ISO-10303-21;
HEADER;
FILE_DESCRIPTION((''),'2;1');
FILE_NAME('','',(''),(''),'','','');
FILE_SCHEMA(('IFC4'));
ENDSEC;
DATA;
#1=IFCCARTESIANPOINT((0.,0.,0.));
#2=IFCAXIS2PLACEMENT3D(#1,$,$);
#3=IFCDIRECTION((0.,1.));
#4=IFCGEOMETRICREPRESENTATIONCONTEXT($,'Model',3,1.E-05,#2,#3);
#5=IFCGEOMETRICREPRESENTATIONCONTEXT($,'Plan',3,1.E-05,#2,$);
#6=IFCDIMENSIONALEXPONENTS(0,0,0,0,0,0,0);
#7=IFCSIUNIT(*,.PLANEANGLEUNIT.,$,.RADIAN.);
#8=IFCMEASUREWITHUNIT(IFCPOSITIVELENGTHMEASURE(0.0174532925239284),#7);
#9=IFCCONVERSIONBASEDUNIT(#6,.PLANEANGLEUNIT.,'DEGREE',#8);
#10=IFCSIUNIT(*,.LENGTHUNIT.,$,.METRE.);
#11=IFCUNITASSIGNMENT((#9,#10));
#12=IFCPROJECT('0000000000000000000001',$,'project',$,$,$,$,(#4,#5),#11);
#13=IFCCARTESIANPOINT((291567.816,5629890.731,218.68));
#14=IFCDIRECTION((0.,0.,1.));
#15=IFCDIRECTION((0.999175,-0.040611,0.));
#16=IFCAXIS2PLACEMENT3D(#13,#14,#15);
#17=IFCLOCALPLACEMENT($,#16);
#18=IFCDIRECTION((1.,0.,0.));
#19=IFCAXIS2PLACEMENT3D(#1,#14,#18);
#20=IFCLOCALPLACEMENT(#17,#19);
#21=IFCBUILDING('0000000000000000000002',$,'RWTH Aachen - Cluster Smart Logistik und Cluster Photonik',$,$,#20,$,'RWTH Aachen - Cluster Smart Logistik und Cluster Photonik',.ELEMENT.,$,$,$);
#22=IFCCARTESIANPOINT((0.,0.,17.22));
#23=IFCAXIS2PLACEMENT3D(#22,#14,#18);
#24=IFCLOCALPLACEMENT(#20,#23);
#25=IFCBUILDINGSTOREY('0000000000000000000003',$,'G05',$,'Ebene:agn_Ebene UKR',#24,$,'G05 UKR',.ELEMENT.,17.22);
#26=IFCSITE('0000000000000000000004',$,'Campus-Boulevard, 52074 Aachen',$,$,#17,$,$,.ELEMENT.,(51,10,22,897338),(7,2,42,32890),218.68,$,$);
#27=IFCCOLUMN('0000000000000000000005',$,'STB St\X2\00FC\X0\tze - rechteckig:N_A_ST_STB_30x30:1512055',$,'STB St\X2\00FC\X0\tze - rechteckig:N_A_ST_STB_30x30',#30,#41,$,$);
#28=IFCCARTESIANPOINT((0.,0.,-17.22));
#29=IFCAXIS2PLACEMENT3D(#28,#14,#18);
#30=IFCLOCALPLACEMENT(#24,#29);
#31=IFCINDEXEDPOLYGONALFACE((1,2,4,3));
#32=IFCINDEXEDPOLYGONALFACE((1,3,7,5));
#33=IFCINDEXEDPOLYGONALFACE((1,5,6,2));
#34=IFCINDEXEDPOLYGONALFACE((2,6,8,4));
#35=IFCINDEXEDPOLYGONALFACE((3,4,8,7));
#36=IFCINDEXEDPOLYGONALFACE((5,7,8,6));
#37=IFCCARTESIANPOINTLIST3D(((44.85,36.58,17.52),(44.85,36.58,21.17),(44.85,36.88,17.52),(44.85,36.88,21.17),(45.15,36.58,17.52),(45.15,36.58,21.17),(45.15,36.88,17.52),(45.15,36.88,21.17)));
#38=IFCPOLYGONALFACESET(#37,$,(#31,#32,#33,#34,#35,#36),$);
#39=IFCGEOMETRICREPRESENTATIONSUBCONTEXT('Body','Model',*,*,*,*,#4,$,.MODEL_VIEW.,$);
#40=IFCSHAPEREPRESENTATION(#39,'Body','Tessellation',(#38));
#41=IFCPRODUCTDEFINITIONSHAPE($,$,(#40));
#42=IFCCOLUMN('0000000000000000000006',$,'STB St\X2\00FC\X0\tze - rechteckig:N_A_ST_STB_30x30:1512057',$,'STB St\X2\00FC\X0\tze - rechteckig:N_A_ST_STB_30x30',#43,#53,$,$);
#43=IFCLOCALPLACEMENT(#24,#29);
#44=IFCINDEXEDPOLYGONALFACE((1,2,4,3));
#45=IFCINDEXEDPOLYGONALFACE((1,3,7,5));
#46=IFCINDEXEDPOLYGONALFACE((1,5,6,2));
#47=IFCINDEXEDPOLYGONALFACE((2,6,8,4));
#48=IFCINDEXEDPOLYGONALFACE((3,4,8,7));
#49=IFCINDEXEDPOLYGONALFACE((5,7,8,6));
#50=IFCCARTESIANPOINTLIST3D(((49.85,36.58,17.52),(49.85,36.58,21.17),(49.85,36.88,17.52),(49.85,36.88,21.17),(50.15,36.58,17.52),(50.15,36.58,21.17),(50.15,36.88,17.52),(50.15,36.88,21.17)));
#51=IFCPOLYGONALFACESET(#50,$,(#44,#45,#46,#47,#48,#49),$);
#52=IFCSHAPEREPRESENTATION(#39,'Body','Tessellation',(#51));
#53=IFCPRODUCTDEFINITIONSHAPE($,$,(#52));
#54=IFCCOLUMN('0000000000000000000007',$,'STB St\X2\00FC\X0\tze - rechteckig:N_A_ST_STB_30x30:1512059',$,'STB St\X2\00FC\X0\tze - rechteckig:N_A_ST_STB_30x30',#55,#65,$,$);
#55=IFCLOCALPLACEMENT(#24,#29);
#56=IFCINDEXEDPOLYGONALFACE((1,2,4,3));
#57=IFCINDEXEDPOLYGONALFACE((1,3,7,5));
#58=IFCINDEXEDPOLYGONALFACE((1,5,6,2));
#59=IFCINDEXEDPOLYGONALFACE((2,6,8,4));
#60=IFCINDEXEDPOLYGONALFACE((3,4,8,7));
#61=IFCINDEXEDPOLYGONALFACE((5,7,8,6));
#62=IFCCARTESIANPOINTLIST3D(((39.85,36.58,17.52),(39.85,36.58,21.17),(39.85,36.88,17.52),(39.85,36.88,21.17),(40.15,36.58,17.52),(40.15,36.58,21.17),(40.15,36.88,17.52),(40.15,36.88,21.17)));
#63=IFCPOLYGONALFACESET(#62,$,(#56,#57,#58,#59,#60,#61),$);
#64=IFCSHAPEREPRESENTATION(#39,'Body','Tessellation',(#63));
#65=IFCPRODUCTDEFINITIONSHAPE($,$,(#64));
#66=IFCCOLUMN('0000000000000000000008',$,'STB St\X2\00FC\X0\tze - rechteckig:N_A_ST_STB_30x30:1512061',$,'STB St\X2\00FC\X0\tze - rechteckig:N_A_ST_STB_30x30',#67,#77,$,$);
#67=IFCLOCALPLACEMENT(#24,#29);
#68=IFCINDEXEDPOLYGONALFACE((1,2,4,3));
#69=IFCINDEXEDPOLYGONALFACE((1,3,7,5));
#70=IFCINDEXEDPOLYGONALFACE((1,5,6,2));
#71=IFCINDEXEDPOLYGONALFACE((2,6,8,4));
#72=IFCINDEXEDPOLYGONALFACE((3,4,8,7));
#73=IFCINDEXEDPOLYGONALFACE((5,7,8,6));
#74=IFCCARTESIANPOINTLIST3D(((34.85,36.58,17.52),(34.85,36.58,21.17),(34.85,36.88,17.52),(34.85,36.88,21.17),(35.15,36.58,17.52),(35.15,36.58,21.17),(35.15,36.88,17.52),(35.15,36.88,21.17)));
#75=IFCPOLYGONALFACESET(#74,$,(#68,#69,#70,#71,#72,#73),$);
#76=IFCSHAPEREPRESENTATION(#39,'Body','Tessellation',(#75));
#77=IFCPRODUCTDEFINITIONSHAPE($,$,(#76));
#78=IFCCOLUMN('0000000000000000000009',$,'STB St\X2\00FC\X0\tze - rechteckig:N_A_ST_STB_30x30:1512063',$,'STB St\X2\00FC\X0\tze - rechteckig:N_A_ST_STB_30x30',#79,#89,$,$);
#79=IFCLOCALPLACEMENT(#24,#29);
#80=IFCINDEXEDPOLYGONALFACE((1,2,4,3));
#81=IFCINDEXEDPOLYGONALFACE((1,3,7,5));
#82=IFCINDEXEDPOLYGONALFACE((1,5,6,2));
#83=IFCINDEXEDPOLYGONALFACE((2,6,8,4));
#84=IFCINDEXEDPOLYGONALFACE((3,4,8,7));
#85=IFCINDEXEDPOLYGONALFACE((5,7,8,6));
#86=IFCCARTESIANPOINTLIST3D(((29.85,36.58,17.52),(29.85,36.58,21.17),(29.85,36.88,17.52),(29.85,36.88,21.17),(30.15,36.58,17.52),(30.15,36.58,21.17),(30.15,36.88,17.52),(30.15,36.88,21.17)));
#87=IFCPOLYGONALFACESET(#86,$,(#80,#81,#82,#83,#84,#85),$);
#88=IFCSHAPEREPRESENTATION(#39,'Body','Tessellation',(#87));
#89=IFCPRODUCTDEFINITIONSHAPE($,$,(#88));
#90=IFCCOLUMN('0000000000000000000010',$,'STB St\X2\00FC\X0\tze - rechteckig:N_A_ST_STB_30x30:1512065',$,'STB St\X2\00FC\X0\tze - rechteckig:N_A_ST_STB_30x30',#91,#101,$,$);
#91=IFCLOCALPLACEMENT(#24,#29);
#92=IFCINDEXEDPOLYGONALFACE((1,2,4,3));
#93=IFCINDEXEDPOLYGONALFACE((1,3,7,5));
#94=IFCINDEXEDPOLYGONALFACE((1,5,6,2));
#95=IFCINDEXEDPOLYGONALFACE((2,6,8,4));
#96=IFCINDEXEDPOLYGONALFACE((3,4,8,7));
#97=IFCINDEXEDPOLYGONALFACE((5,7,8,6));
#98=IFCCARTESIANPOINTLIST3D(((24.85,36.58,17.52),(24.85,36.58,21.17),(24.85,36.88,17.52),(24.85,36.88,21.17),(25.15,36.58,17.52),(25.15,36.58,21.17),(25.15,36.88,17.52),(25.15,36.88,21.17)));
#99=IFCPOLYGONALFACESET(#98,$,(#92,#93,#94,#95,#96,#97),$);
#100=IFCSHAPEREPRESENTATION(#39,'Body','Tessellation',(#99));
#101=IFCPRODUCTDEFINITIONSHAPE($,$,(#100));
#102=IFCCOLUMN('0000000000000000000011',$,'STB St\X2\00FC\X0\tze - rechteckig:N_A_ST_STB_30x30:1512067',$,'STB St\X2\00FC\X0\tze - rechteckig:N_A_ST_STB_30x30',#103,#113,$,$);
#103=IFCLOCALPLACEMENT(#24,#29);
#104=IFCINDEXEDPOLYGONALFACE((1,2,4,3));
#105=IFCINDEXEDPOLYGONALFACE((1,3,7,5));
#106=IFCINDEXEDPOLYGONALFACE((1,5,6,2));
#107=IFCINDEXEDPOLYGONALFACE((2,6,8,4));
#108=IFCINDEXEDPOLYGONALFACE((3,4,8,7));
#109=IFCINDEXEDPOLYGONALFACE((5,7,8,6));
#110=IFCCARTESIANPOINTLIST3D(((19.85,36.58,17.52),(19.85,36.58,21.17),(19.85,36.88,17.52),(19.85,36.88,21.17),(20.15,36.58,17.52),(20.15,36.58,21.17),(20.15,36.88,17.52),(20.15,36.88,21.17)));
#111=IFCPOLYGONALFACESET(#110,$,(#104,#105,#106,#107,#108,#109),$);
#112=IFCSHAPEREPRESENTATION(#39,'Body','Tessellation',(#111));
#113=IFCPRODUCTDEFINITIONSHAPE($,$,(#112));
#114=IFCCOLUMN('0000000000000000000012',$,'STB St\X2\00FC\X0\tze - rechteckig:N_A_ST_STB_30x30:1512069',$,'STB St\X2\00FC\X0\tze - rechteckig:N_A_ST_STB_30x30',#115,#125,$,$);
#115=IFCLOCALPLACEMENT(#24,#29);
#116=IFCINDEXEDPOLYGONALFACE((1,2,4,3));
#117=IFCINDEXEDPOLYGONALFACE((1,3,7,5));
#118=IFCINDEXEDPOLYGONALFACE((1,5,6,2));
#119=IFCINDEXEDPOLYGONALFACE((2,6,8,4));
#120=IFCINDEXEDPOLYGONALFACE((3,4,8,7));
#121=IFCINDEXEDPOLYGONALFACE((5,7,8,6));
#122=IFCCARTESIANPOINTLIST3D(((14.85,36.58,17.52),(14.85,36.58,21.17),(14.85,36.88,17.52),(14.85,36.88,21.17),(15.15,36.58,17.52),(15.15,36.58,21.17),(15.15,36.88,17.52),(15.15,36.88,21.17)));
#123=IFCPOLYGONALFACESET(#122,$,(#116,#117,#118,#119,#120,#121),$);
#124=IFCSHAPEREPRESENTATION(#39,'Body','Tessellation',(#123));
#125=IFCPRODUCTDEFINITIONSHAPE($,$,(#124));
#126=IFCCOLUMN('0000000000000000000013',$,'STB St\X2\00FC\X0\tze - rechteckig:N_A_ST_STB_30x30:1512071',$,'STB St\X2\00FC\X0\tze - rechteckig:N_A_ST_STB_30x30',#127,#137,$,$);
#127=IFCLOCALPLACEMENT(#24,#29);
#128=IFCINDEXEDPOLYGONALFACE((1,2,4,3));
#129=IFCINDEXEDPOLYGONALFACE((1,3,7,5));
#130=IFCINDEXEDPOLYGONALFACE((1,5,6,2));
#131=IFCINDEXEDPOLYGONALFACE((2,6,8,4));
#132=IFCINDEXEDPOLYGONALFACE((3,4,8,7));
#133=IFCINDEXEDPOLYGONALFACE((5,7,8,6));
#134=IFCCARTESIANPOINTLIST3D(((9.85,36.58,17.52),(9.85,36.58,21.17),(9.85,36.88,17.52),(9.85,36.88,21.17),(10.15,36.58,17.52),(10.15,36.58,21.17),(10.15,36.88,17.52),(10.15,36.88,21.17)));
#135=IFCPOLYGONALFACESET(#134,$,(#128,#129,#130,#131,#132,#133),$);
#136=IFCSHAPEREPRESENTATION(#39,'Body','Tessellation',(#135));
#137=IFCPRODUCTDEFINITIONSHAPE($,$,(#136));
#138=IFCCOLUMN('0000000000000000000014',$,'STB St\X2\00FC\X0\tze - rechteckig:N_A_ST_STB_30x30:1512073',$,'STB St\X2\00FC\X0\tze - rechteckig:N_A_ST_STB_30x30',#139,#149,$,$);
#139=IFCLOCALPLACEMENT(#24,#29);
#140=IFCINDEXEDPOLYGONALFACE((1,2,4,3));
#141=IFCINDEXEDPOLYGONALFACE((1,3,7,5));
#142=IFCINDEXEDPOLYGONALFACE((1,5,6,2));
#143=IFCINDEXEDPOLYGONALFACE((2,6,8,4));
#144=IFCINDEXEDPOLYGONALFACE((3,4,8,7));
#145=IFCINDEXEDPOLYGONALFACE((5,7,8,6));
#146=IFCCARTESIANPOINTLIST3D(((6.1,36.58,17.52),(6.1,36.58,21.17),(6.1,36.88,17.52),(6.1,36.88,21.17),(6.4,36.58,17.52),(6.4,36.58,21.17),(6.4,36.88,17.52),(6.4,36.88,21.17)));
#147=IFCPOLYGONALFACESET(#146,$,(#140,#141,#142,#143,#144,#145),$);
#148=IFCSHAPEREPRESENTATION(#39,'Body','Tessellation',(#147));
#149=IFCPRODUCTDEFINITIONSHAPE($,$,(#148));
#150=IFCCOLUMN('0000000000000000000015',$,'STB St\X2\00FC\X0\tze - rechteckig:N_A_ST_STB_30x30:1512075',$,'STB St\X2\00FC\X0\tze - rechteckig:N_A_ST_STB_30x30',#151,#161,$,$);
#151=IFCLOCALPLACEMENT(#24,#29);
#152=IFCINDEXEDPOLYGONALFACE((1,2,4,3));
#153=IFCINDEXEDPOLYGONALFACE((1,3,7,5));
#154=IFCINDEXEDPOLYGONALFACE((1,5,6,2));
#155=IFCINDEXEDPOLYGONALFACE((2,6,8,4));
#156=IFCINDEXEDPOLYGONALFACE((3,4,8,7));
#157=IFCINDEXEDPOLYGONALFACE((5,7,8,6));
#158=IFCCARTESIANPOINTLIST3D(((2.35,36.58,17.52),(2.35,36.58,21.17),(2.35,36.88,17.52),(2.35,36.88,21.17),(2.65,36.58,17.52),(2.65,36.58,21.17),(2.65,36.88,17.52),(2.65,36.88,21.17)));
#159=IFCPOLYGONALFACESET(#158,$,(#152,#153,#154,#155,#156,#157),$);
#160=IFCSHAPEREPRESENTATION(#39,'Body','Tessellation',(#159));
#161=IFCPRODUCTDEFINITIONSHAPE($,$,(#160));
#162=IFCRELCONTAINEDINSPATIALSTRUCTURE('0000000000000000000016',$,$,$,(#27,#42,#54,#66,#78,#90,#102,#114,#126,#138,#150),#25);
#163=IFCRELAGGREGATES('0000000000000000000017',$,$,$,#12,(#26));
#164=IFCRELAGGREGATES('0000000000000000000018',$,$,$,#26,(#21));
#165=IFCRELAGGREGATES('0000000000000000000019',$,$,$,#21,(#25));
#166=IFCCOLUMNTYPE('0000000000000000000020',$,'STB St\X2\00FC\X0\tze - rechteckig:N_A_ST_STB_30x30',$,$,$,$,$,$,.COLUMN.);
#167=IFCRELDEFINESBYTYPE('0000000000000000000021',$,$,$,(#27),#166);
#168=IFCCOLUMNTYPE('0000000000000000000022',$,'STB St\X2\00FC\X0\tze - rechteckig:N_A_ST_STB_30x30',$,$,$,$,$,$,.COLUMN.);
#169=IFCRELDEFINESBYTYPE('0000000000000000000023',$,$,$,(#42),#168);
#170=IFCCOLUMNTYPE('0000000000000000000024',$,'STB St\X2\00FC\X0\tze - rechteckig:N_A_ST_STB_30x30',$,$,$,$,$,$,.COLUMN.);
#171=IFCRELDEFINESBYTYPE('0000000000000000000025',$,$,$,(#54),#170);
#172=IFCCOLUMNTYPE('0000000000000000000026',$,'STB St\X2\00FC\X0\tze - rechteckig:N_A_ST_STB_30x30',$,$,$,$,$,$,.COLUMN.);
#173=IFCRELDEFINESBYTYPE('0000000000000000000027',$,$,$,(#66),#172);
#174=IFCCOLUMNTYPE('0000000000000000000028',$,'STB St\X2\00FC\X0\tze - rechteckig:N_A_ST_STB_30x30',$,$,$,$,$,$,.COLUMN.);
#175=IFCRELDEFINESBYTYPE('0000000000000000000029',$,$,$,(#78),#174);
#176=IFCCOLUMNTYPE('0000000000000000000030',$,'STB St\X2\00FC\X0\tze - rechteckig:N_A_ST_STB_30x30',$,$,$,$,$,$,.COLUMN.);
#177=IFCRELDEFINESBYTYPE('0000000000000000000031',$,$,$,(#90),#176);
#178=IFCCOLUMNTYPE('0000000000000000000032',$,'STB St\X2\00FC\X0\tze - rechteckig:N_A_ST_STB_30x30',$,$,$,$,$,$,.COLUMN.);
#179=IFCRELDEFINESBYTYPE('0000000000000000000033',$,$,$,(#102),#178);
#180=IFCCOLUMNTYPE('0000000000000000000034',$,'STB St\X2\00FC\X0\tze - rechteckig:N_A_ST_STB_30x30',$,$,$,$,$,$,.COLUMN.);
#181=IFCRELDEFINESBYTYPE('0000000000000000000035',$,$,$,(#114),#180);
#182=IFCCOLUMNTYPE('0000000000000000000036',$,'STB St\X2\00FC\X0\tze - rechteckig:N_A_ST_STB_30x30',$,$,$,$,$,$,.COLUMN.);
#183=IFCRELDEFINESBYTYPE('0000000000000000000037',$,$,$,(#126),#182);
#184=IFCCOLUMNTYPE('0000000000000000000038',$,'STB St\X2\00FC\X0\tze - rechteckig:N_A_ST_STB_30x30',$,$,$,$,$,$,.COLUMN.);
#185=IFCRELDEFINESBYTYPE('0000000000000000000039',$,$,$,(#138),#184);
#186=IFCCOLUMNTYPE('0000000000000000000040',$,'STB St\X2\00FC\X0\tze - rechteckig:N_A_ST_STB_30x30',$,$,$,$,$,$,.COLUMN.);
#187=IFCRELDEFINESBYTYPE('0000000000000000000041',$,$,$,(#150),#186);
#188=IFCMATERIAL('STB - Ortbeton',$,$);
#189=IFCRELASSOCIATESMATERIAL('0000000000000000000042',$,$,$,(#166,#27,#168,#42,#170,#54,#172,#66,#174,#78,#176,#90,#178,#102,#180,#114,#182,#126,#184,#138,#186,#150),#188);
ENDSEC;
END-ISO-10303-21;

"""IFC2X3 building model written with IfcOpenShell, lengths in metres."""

from ifc_helpers import new_model, entity, si_unit, converted_unit, direction, frame, frame_2d, origin, origin_with_axes, origin_2d_with_axis, place, context, subcontext, project, spatial, rectangle, extrude, source, transform, mapped, material, type_object, element, save


model = new_model("IFC2X3")

# Units and contexts
model_context = context("Model", 3, precision=1e-05, world=origin(), true_north=direction((0.0, 1.0)))
plan_context = context("Plan", 3, precision=1e-05, world=origin())
body_context = subcontext(model_context, "Body", "Model", "MODEL_VIEW")
ifc_project = project(units=[converted_unit("PLANEANGLEUNIT", "DEGREE", entity("IfcPositiveLengthMeasure", 0.0174532925239284), si_unit("PLANEANGLEUNIT", "RADIAN"), dimensions=[0, 0, 0, 0, 0, 0, 0]), si_unit("LENGTHUNIT", "METRE")], contexts=[model_context, plan_context])

# Site, building, storey
site_placement = place(None, frame((291567.816, 5629890.731, 218.68), z_axis=(0.0, 0.0, 1.0), x_axis=(0.999175, -0.040611, 0.0)))
site = spatial("IfcSite", under=ifc_project, at=site_placement, Name="Campus-Boulevard, 52074 Aachen", CompositionType="ELEMENT", RefLatitude=(51, 10, 22, 897338), RefLongitude=(7, 2, 42, 32890), RefElevation=218.68)
building_placement = place(site_placement, origin_with_axes())
building = spatial("IfcBuilding", under=site, at=building_placement, Name="RWTH Aachen - Cluster Smart Logistik und Cluster Photonik", LongName="RWTH Aachen - Cluster Smart Logistik und Cluster Photonik", CompositionType="ELEMENT")
storey_placement = place(building_placement, frame((0.0, 0.0, 17.22), z_axis=(0.0, 0.0, 1.0), x_axis=(1.0, 0.0, 0.0)))
storey = spatial("IfcBuildingStorey", under=building, at=storey_placement, Name="G05", ObjectType="Ebene:agn_Ebene UKR", LongName="G05 UKR", CompositionType="ELEMENT", Elevation=17.22)

# Columns
ifc_material = material(Name="STB - Ortbeton")
column_type_1 = type_object("IfcColumnType", Name="STB Stütze - rechteckig:N_A_ST_STB_30x30", PredefinedType="COLUMN", material=ifc_material)
shared_shape_1 = source(origin(), body_context, "Body", "SweptSolid", [
    extrude(rectangle(XDim=0.3, YDim=0.3, at=origin_2d_with_axis()), frame((45.0, 36.73, 17.52), z_axis=(0.0, 0.0, 1.0), x_axis=(0.0, -1.0, 0.0)), (0.0, 0.0, 1.0), 3.65),
])
column_1_placement = place(storey_placement, frame((0.0, 0.0, -17.22), z_axis=(0.0, 0.0, 1.0), x_axis=(1.0, 0.0, 0.0)))
element("IfcColumn", 1, at=column_1_placement, inside=storey, type_object=column_type_1, material=ifc_material, Name="STB Stütze - rechteckig:N_A_ST_STB_30x30:1512055", ObjectType="STB Stütze - rechteckig:N_A_ST_STB_30x30", context=body_context, shape_type="MappedRepresentation", body=[
    mapped(shared_shape_1, transform((0.0, 0.0, 0.0), scale=1.0)),
])
column_type_2 = type_object("IfcColumnType", Name="STB Stütze - rechteckig:N_A_ST_STB_30x30", PredefinedType="COLUMN", material=ifc_material)
shared_shape_2 = source(origin(), body_context, "Body", "SweptSolid", [
    extrude(rectangle(XDim=0.3, YDim=0.3, at=origin_2d_with_axis()), frame((50.0, 36.73, 17.52), z_axis=(0.0, 0.0, 1.0), x_axis=(0.0, -1.0, 0.0)), (0.0, 0.0, 1.0), 3.65),
])
column_2_placement = place(storey_placement, frame((0.0, 0.0, -17.22), z_axis=(0.0, 0.0, 1.0), x_axis=(1.0, 0.0, 0.0)))
element("IfcColumn", 2, at=column_2_placement, inside=storey, type_object=column_type_2, material=ifc_material, Name="STB Stütze - rechteckig:N_A_ST_STB_30x30:1512057", ObjectType="STB Stütze - rechteckig:N_A_ST_STB_30x30", context=body_context, shape_type="MappedRepresentation", body=[
    mapped(shared_shape_2, transform((0.0, 0.0, 0.0), scale=1.0)),
])
column_type_3 = type_object("IfcColumnType", Name="STB Stütze - rechteckig:N_A_ST_STB_30x30", PredefinedType="COLUMN", material=ifc_material)
shared_shape_3 = source(origin(), body_context, "Body", "SweptSolid", [
    extrude(rectangle(XDim=0.3, YDim=0.3, at=origin_2d_with_axis()), frame((40.0, 36.73, 17.52), z_axis=(0.0, 0.0, 1.0), x_axis=(0.0, -1.0, 0.0)), (0.0, 0.0, 1.0), 3.65),
])
column_3_placement = place(storey_placement, frame((0.0, 0.0, -17.22), z_axis=(0.0, 0.0, 1.0), x_axis=(1.0, 0.0, 0.0)))
element("IfcColumn", 3, at=column_3_placement, inside=storey, type_object=column_type_3, material=ifc_material, Name="STB Stütze - rechteckig:N_A_ST_STB_30x30:1512059", ObjectType="STB Stütze - rechteckig:N_A_ST_STB_30x30", context=body_context, shape_type="MappedRepresentation", body=[
    mapped(shared_shape_3, transform((0.0, 0.0, 0.0), scale=1.0)),
])
column_type_4 = type_object("IfcColumnType", Name="STB Stütze - rechteckig:N_A_ST_STB_30x30", PredefinedType="COLUMN", material=ifc_material)
shared_shape_4 = source(origin(), body_context, "Body", "SweptSolid", [
    extrude(rectangle(XDim=0.3, YDim=0.3, at=origin_2d_with_axis()), frame((35.0, 36.73, 17.52), z_axis=(0.0, 0.0, 1.0), x_axis=(0.0, -1.0, 0.0)), (0.0, 0.0, 1.0), 3.65),
])
column_4_placement = place(storey_placement, frame((0.0, 0.0, -17.22), z_axis=(0.0, 0.0, 1.0), x_axis=(1.0, 0.0, 0.0)))
element("IfcColumn", 4, at=column_4_placement, inside=storey, type_object=column_type_4, material=ifc_material, Name="STB Stütze - rechteckig:N_A_ST_STB_30x30:1512061", ObjectType="STB Stütze - rechteckig:N_A_ST_STB_30x30", context=body_context, shape_type="MappedRepresentation", body=[
    mapped(shared_shape_4, transform((0.0, 0.0, 0.0), scale=1.0)),
])
column_type_5 = type_object("IfcColumnType", Name="STB Stütze - rechteckig:N_A_ST_STB_30x30", PredefinedType="COLUMN", material=ifc_material)
shared_shape_5 = source(origin(), body_context, "Body", "SweptSolid", [
    extrude(rectangle(XDim=0.3, YDim=0.3, at=origin_2d_with_axis()), frame((30.0, 36.73, 17.52), z_axis=(0.0, 0.0, 1.0), x_axis=(0.0, -1.0, 0.0)), (0.0, 0.0, 1.0), 3.65),
])
column_5_placement = place(storey_placement, frame((0.0, 0.0, -17.22), z_axis=(0.0, 0.0, 1.0), x_axis=(1.0, 0.0, 0.0)))
element("IfcColumn", 5, at=column_5_placement, inside=storey, type_object=column_type_5, material=ifc_material, Name="STB Stütze - rechteckig:N_A_ST_STB_30x30:1512063", ObjectType="STB Stütze - rechteckig:N_A_ST_STB_30x30", context=body_context, shape_type="MappedRepresentation", body=[
    mapped(shared_shape_5, transform((0.0, 0.0, 0.0), scale=1.0)),
])
column_type_6 = type_object("IfcColumnType", Name="STB Stütze - rechteckig:N_A_ST_STB_30x30", PredefinedType="COLUMN", material=ifc_material)
shared_shape_6 = source(origin(), body_context, "Body", "SweptSolid", [
    extrude(rectangle(XDim=0.3, YDim=0.3, at=origin_2d_with_axis()), frame((25.0, 36.73, 17.52), z_axis=(0.0, 0.0, 1.0), x_axis=(0.0, -1.0, 0.0)), (0.0, 0.0, 1.0), 3.65),
])
column_6_placement = place(storey_placement, frame((0.0, 0.0, -17.22), z_axis=(0.0, 0.0, 1.0), x_axis=(1.0, 0.0, 0.0)))
element("IfcColumn", 6, at=column_6_placement, inside=storey, type_object=column_type_6, material=ifc_material, Name="STB Stütze - rechteckig:N_A_ST_STB_30x30:1512065", ObjectType="STB Stütze - rechteckig:N_A_ST_STB_30x30", context=body_context, shape_type="MappedRepresentation", body=[
    mapped(shared_shape_6, transform((0.0, 0.0, 0.0), scale=1.0)),
])
column_type_7 = type_object("IfcColumnType", Name="STB Stütze - rechteckig:N_A_ST_STB_30x30", PredefinedType="COLUMN", material=ifc_material)
shared_shape_7 = source(origin(), body_context, "Body", "SweptSolid", [
    extrude(rectangle(XDim=0.3, YDim=0.3, at=origin_2d_with_axis()), frame((20.0, 36.73, 17.52), z_axis=(0.0, 0.0, 1.0), x_axis=(0.0, -1.0, 0.0)), (0.0, 0.0, 1.0), 3.65),
])
column_7_placement = place(storey_placement, frame((0.0, 0.0, -17.22), z_axis=(0.0, 0.0, 1.0), x_axis=(1.0, 0.0, 0.0)))
element("IfcColumn", 7, at=column_7_placement, inside=storey, type_object=column_type_7, material=ifc_material, Name="STB Stütze - rechteckig:N_A_ST_STB_30x30:1512067", ObjectType="STB Stütze - rechteckig:N_A_ST_STB_30x30", context=body_context, shape_type="MappedRepresentation", body=[
    mapped(shared_shape_7, transform((0.0, 0.0, 0.0), scale=1.0)),
])
column_type_8 = type_object("IfcColumnType", Name="STB Stütze - rechteckig:N_A_ST_STB_30x30", PredefinedType="COLUMN", material=ifc_material)
shared_shape_8 = source(origin(), body_context, "Body", "SweptSolid", [
    extrude(rectangle(XDim=0.3, YDim=0.3, at=origin_2d_with_axis()), frame((15.0, 36.73, 17.52), z_axis=(0.0, 0.0, 1.0), x_axis=(0.0, -1.0, 0.0)), (0.0, 0.0, 1.0), 3.65),
])
column_8_placement = place(storey_placement, frame((0.0, 0.0, -17.22), z_axis=(0.0, 0.0, 1.0), x_axis=(1.0, 0.0, 0.0)))
element("IfcColumn", 8, at=column_8_placement, inside=storey, type_object=column_type_8, material=ifc_material, Name="STB Stütze - rechteckig:N_A_ST_STB_30x30:1512069", ObjectType="STB Stütze - rechteckig:N_A_ST_STB_30x30", context=body_context, shape_type="MappedRepresentation", body=[
    mapped(shared_shape_8, transform((0.0, 0.0, 0.0), scale=1.0)),
])
column_type_9 = type_object("IfcColumnType", Name="STB Stütze - rechteckig:N_A_ST_STB_30x30", PredefinedType="COLUMN", material=ifc_material)
shared_shape_9 = source(origin(), body_context, "Body", "SweptSolid", [
    extrude(rectangle(XDim=0.3, YDim=0.3, at=origin_2d_with_axis()), frame((10.0, 36.73, 17.52), z_axis=(0.0, 0.0, 1.0), x_axis=(0.0, -1.0, 0.0)), (0.0, 0.0, 1.0), 3.65),
])
column_9_placement = place(storey_placement, frame((0.0, 0.0, -17.22), z_axis=(0.0, 0.0, 1.0), x_axis=(1.0, 0.0, 0.0)))
element("IfcColumn", 9, at=column_9_placement, inside=storey, type_object=column_type_9, material=ifc_material, Name="STB Stütze - rechteckig:N_A_ST_STB_30x30:1512071", ObjectType="STB Stütze - rechteckig:N_A_ST_STB_30x30", context=body_context, shape_type="MappedRepresentation", body=[
    mapped(shared_shape_9, transform((0.0, 0.0, 0.0), scale=1.0)),
])
column_type_10 = type_object("IfcColumnType", Name="STB Stütze - rechteckig:N_A_ST_STB_30x30", PredefinedType="COLUMN", material=ifc_material)
shared_shape_10 = source(origin(), body_context, "Body", "SweptSolid", [
    extrude(rectangle(XDim=0.3, YDim=0.3, at=frame_2d((0.0, 0.0), x_axis=(1.0, 0.0))), frame((6.25, 36.73, 17.52), z_axis=(0.0, 0.0, 1.0), x_axis=(0.0, -1.0, 0.0)), (0.0, 0.0, 1.0), 3.65),
])
column_10_placement = place(storey_placement, frame((0.0, 0.0, -17.22), z_axis=(0.0, 0.0, 1.0), x_axis=(1.0, 0.0, 0.0)))
element("IfcColumn", 10, at=column_10_placement, inside=storey, type_object=column_type_10, material=ifc_material, Name="STB Stütze - rechteckig:N_A_ST_STB_30x30:1512073", ObjectType="STB Stütze - rechteckig:N_A_ST_STB_30x30", context=body_context, shape_type="MappedRepresentation", body=[
    mapped(shared_shape_10, transform((0.0, 0.0, 0.0), scale=1.0)),
])
column_type_11 = type_object("IfcColumnType", Name="STB Stütze - rechteckig:N_A_ST_STB_30x30", PredefinedType="COLUMN", material=ifc_material)
shared_shape_11 = source(origin(), body_context, "Body", "SweptSolid", [
    extrude(rectangle(XDim=0.3, YDim=0.3, at=origin_2d_with_axis()), frame((2.5, 36.73, 17.52), z_axis=(0.0, 0.0, 1.0), x_axis=(0.0, -1.0, 0.0)), (0.0, 0.0, 1.0), 3.65),
])
column_11_placement = place(storey_placement, frame((0.0, 0.0, -17.22), z_axis=(0.0, 0.0, 1.0), x_axis=(1.0, 0.0, 0.0)))
element("IfcColumn", 11, at=column_11_placement, inside=storey, type_object=column_type_11, material=ifc_material, Name="STB Stütze - rechteckig:N_A_ST_STB_30x30:1512075", ObjectType="STB Stütze - rechteckig:N_A_ST_STB_30x30", context=body_context, shape_type="MappedRepresentation", body=[
    mapped(shared_shape_11, transform((0.0, 0.0, 0.0), scale=1.0)),
])

save(model, "model.ifc")
